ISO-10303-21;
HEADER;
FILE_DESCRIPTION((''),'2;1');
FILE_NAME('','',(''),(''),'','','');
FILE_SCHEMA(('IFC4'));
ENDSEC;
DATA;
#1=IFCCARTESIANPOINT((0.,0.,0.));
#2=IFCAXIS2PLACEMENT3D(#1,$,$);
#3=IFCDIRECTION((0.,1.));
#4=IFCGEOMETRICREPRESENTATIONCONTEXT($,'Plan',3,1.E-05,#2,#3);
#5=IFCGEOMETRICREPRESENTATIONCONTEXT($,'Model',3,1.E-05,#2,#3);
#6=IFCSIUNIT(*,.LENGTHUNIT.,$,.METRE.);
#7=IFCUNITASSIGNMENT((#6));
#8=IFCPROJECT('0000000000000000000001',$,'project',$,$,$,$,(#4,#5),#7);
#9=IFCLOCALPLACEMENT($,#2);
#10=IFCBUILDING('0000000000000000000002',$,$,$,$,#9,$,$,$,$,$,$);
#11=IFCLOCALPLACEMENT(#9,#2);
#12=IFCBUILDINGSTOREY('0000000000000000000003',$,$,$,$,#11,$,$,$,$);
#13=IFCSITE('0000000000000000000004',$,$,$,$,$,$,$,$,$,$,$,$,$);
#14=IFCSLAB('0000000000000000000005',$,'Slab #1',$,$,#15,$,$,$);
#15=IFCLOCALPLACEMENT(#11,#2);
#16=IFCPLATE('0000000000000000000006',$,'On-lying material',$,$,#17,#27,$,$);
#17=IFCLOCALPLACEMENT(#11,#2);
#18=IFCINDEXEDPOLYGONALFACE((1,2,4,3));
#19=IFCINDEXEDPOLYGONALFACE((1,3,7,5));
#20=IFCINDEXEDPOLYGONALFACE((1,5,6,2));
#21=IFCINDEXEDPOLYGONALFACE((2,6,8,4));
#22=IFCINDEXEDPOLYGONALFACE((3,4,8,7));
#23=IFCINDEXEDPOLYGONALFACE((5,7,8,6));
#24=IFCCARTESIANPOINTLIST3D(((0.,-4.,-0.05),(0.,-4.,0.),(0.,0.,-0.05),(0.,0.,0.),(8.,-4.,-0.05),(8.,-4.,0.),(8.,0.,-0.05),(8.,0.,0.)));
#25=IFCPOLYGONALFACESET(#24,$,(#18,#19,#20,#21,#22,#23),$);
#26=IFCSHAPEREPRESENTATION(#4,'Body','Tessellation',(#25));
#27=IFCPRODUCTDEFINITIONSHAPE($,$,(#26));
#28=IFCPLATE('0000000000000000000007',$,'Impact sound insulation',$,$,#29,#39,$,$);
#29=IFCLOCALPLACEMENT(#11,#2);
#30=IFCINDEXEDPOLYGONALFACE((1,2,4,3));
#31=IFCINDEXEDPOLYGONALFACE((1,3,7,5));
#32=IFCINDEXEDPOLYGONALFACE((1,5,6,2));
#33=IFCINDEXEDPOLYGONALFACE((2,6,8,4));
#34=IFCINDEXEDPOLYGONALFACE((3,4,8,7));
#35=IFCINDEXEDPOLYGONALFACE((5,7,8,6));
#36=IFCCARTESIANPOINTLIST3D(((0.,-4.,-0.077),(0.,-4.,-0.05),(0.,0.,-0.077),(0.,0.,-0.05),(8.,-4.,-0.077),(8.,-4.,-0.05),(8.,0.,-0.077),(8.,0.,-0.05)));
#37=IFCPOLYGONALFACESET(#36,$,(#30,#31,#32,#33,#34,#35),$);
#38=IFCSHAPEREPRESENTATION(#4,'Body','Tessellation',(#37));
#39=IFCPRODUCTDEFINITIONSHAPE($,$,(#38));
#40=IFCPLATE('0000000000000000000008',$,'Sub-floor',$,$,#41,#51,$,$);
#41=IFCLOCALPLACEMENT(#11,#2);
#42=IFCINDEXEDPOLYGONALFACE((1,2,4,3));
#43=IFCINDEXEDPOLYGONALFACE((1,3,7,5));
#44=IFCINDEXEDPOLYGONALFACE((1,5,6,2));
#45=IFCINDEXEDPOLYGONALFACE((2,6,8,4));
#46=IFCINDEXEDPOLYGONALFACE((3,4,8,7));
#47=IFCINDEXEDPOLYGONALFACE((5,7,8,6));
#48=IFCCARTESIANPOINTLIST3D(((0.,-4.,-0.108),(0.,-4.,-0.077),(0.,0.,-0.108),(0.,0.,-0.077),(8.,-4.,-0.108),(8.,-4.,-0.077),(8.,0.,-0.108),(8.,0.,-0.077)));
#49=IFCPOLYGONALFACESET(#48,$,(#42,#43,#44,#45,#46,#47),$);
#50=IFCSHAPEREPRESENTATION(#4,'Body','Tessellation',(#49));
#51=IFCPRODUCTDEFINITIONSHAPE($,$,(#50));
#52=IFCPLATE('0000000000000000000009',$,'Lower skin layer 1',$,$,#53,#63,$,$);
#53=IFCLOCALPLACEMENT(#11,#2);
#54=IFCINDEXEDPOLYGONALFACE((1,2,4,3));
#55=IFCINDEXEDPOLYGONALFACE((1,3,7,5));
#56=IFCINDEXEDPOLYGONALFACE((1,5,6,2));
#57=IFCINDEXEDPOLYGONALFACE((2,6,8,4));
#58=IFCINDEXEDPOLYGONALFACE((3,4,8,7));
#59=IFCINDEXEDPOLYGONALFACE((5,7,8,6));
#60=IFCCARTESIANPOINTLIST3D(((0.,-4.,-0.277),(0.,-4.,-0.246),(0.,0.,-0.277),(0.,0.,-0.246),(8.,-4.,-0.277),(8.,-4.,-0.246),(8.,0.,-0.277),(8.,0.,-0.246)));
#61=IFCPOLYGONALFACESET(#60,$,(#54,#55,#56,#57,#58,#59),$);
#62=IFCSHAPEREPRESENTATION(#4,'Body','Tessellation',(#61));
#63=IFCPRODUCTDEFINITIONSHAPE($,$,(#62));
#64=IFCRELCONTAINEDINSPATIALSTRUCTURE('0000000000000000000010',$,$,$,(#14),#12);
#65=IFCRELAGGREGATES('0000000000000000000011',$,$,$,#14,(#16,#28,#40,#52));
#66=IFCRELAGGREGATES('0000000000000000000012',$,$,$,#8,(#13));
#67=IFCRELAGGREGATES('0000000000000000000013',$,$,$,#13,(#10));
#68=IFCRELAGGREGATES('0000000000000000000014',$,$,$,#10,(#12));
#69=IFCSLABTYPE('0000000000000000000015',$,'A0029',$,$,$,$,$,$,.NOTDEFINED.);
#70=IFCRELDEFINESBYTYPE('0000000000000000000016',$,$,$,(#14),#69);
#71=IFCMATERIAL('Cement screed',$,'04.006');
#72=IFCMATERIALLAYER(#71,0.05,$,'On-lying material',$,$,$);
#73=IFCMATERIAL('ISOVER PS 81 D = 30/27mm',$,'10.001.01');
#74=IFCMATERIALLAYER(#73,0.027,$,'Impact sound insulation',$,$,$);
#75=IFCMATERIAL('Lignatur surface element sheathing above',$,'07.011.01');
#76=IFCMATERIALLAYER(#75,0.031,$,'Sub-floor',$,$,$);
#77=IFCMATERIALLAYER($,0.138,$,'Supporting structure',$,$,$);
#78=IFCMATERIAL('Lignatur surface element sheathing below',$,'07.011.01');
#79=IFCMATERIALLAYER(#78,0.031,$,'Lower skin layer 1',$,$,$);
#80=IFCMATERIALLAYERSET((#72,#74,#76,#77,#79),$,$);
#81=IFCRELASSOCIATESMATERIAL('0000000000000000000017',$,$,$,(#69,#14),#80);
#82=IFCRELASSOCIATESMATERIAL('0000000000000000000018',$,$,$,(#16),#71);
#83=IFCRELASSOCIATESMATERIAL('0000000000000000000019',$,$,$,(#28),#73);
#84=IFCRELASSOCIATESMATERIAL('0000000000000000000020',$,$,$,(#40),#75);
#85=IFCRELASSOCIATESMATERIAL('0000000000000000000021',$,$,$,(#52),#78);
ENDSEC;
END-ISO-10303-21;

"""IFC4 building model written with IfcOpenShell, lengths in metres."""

from ifc_helpers import new_model, si_unit, direction, frame, frame_2d, origin, origin_with_axes, place, context, project, spatial, rectangle, extrude, material, layer, layer_set, type_object, element, aggregate, save


model = new_model("IFC4")

# Units and contexts
plan_context = context("Plan", 3, precision=1e-05, world=origin(), true_north=direction((0.0, 1.0)))
model_context = context("Model", 3, precision=1e-05, world=origin(), true_north=direction((0.0, 1.0)))
ifc_project = project(units=[si_unit("LENGTHUNIT", "METRE")], contexts=[plan_context, model_context])

# Site, building, storey
site = spatial("IfcSite", under=ifc_project)
building_placement = place(None, origin())
building = spatial("IfcBuilding", under=site, at=building_placement)
storey_placement = place(building_placement, origin())
storey = spatial("IfcBuildingStorey", under=building, at=storey_placement)

# Slab, plates
ifc_material_1 = material(Name="Cement screed", Category="04.006")
ifc_layer_1 = layer(ifc_material_1, 0.05, Name="On-lying material")
ifc_material_2 = material(Name="ISOVER PS 81 D = 30/27mm", Category="10.001.01")
ifc_layer_2 = layer(ifc_material_2, 0.027, Name="Impact sound insulation")
ifc_material_3 = material(Name="Lignatur surface element sheathing above", Category="07.011.01")
ifc_layer_3 = layer(ifc_material_3, 0.031, Name="Sub-floor")
ifc_layer_4 = layer(None, 0.138, Name="Supporting structure")
ifc_material_4 = material(Name="Lignatur surface element sheathing below", Category="07.011.01")
ifc_layer_5 = layer(ifc_material_4, 0.031, Name="Lower skin layer 1")
ifc_layer_set = layer_set([ifc_layer_1, ifc_layer_2, ifc_layer_3, ifc_layer_4, ifc_layer_5])
slab_type = type_object("IfcSlabType", Name="A0029", PredefinedType="NOTDEFINED", material=ifc_layer_set)
slab_placement = place(None, frame((0.0, 0.0, 0.0), z_axis=(0.0, 0.0, -1.0), x_axis=(1.0, 0.0, 0.0)))
slab = element("IfcSlab", 1, at=slab_placement, inside=storey, type_object=slab_type, material=ifc_layer_set, Name="Slab #1")
plate_1_placement = place(slab_placement, origin())
plate_1 = element("IfcPlate", 2, at=plate_1_placement, material=ifc_material_1, Name="On-lying material", context=plan_context, shape_type="SweptSolid", body=[
    extrude(rectangle(XDim=8.0, YDim=4.0, at=frame_2d((4.0, 2.0), x_axis=(1.0, 0.0))), origin_with_axes(), (0.0, 0.0, 1.0), 0.05),
])
plate_2_placement = place(slab_placement, origin())
plate_2 = element("IfcPlate", 3, at=plate_2_placement, material=ifc_material_2, Name="Impact sound insulation", context=plan_context, shape_type="SweptSolid", body=[
    extrude(rectangle(XDim=8.0, YDim=4.0, at=frame_2d((4.0, 2.0), x_axis=(1.0, 0.0))), frame((0.0, 0.0, 0.05), z_axis=(0.0, 0.0, 1.0), x_axis=(1.0, 0.0, 0.0)), (0.0, 0.0, 1.0), 0.027),
])
plate_3_placement = place(slab_placement, origin())
plate_3 = element("IfcPlate", 4, at=plate_3_placement, material=ifc_material_3, Name="Sub-floor", context=plan_context, shape_type="SweptSolid", body=[
    extrude(rectangle(XDim=8.0, YDim=4.0, at=frame_2d((4.0, 2.0), x_axis=(1.0, 0.0))), frame((0.0, 0.0, 0.077), z_axis=(0.0, 0.0, 1.0), x_axis=(1.0, 0.0, 0.0)), (0.0, 0.0, 1.0), 0.031),
])
plate_4_placement = place(slab_placement, origin())
plate_4 = element("IfcPlate", 5, at=plate_4_placement, material=ifc_material_4, Name="Lower skin layer 1", context=plan_context, shape_type="SweptSolid", body=[
    extrude(rectangle(XDim=8.0, YDim=4.0, at=frame_2d((4.0, 2.0), x_axis=(1.0, 0.0))), frame((0.0, 0.0, 0.246), z_axis=(0.0, 0.0, 1.0), x_axis=(1.0, 0.0, 0.0)), (0.0, 0.0, 1.0), 0.031),
])
aggregate(slab, [plate_1, plate_2, plate_3, plate_4])

save(model, "model.ifc")
